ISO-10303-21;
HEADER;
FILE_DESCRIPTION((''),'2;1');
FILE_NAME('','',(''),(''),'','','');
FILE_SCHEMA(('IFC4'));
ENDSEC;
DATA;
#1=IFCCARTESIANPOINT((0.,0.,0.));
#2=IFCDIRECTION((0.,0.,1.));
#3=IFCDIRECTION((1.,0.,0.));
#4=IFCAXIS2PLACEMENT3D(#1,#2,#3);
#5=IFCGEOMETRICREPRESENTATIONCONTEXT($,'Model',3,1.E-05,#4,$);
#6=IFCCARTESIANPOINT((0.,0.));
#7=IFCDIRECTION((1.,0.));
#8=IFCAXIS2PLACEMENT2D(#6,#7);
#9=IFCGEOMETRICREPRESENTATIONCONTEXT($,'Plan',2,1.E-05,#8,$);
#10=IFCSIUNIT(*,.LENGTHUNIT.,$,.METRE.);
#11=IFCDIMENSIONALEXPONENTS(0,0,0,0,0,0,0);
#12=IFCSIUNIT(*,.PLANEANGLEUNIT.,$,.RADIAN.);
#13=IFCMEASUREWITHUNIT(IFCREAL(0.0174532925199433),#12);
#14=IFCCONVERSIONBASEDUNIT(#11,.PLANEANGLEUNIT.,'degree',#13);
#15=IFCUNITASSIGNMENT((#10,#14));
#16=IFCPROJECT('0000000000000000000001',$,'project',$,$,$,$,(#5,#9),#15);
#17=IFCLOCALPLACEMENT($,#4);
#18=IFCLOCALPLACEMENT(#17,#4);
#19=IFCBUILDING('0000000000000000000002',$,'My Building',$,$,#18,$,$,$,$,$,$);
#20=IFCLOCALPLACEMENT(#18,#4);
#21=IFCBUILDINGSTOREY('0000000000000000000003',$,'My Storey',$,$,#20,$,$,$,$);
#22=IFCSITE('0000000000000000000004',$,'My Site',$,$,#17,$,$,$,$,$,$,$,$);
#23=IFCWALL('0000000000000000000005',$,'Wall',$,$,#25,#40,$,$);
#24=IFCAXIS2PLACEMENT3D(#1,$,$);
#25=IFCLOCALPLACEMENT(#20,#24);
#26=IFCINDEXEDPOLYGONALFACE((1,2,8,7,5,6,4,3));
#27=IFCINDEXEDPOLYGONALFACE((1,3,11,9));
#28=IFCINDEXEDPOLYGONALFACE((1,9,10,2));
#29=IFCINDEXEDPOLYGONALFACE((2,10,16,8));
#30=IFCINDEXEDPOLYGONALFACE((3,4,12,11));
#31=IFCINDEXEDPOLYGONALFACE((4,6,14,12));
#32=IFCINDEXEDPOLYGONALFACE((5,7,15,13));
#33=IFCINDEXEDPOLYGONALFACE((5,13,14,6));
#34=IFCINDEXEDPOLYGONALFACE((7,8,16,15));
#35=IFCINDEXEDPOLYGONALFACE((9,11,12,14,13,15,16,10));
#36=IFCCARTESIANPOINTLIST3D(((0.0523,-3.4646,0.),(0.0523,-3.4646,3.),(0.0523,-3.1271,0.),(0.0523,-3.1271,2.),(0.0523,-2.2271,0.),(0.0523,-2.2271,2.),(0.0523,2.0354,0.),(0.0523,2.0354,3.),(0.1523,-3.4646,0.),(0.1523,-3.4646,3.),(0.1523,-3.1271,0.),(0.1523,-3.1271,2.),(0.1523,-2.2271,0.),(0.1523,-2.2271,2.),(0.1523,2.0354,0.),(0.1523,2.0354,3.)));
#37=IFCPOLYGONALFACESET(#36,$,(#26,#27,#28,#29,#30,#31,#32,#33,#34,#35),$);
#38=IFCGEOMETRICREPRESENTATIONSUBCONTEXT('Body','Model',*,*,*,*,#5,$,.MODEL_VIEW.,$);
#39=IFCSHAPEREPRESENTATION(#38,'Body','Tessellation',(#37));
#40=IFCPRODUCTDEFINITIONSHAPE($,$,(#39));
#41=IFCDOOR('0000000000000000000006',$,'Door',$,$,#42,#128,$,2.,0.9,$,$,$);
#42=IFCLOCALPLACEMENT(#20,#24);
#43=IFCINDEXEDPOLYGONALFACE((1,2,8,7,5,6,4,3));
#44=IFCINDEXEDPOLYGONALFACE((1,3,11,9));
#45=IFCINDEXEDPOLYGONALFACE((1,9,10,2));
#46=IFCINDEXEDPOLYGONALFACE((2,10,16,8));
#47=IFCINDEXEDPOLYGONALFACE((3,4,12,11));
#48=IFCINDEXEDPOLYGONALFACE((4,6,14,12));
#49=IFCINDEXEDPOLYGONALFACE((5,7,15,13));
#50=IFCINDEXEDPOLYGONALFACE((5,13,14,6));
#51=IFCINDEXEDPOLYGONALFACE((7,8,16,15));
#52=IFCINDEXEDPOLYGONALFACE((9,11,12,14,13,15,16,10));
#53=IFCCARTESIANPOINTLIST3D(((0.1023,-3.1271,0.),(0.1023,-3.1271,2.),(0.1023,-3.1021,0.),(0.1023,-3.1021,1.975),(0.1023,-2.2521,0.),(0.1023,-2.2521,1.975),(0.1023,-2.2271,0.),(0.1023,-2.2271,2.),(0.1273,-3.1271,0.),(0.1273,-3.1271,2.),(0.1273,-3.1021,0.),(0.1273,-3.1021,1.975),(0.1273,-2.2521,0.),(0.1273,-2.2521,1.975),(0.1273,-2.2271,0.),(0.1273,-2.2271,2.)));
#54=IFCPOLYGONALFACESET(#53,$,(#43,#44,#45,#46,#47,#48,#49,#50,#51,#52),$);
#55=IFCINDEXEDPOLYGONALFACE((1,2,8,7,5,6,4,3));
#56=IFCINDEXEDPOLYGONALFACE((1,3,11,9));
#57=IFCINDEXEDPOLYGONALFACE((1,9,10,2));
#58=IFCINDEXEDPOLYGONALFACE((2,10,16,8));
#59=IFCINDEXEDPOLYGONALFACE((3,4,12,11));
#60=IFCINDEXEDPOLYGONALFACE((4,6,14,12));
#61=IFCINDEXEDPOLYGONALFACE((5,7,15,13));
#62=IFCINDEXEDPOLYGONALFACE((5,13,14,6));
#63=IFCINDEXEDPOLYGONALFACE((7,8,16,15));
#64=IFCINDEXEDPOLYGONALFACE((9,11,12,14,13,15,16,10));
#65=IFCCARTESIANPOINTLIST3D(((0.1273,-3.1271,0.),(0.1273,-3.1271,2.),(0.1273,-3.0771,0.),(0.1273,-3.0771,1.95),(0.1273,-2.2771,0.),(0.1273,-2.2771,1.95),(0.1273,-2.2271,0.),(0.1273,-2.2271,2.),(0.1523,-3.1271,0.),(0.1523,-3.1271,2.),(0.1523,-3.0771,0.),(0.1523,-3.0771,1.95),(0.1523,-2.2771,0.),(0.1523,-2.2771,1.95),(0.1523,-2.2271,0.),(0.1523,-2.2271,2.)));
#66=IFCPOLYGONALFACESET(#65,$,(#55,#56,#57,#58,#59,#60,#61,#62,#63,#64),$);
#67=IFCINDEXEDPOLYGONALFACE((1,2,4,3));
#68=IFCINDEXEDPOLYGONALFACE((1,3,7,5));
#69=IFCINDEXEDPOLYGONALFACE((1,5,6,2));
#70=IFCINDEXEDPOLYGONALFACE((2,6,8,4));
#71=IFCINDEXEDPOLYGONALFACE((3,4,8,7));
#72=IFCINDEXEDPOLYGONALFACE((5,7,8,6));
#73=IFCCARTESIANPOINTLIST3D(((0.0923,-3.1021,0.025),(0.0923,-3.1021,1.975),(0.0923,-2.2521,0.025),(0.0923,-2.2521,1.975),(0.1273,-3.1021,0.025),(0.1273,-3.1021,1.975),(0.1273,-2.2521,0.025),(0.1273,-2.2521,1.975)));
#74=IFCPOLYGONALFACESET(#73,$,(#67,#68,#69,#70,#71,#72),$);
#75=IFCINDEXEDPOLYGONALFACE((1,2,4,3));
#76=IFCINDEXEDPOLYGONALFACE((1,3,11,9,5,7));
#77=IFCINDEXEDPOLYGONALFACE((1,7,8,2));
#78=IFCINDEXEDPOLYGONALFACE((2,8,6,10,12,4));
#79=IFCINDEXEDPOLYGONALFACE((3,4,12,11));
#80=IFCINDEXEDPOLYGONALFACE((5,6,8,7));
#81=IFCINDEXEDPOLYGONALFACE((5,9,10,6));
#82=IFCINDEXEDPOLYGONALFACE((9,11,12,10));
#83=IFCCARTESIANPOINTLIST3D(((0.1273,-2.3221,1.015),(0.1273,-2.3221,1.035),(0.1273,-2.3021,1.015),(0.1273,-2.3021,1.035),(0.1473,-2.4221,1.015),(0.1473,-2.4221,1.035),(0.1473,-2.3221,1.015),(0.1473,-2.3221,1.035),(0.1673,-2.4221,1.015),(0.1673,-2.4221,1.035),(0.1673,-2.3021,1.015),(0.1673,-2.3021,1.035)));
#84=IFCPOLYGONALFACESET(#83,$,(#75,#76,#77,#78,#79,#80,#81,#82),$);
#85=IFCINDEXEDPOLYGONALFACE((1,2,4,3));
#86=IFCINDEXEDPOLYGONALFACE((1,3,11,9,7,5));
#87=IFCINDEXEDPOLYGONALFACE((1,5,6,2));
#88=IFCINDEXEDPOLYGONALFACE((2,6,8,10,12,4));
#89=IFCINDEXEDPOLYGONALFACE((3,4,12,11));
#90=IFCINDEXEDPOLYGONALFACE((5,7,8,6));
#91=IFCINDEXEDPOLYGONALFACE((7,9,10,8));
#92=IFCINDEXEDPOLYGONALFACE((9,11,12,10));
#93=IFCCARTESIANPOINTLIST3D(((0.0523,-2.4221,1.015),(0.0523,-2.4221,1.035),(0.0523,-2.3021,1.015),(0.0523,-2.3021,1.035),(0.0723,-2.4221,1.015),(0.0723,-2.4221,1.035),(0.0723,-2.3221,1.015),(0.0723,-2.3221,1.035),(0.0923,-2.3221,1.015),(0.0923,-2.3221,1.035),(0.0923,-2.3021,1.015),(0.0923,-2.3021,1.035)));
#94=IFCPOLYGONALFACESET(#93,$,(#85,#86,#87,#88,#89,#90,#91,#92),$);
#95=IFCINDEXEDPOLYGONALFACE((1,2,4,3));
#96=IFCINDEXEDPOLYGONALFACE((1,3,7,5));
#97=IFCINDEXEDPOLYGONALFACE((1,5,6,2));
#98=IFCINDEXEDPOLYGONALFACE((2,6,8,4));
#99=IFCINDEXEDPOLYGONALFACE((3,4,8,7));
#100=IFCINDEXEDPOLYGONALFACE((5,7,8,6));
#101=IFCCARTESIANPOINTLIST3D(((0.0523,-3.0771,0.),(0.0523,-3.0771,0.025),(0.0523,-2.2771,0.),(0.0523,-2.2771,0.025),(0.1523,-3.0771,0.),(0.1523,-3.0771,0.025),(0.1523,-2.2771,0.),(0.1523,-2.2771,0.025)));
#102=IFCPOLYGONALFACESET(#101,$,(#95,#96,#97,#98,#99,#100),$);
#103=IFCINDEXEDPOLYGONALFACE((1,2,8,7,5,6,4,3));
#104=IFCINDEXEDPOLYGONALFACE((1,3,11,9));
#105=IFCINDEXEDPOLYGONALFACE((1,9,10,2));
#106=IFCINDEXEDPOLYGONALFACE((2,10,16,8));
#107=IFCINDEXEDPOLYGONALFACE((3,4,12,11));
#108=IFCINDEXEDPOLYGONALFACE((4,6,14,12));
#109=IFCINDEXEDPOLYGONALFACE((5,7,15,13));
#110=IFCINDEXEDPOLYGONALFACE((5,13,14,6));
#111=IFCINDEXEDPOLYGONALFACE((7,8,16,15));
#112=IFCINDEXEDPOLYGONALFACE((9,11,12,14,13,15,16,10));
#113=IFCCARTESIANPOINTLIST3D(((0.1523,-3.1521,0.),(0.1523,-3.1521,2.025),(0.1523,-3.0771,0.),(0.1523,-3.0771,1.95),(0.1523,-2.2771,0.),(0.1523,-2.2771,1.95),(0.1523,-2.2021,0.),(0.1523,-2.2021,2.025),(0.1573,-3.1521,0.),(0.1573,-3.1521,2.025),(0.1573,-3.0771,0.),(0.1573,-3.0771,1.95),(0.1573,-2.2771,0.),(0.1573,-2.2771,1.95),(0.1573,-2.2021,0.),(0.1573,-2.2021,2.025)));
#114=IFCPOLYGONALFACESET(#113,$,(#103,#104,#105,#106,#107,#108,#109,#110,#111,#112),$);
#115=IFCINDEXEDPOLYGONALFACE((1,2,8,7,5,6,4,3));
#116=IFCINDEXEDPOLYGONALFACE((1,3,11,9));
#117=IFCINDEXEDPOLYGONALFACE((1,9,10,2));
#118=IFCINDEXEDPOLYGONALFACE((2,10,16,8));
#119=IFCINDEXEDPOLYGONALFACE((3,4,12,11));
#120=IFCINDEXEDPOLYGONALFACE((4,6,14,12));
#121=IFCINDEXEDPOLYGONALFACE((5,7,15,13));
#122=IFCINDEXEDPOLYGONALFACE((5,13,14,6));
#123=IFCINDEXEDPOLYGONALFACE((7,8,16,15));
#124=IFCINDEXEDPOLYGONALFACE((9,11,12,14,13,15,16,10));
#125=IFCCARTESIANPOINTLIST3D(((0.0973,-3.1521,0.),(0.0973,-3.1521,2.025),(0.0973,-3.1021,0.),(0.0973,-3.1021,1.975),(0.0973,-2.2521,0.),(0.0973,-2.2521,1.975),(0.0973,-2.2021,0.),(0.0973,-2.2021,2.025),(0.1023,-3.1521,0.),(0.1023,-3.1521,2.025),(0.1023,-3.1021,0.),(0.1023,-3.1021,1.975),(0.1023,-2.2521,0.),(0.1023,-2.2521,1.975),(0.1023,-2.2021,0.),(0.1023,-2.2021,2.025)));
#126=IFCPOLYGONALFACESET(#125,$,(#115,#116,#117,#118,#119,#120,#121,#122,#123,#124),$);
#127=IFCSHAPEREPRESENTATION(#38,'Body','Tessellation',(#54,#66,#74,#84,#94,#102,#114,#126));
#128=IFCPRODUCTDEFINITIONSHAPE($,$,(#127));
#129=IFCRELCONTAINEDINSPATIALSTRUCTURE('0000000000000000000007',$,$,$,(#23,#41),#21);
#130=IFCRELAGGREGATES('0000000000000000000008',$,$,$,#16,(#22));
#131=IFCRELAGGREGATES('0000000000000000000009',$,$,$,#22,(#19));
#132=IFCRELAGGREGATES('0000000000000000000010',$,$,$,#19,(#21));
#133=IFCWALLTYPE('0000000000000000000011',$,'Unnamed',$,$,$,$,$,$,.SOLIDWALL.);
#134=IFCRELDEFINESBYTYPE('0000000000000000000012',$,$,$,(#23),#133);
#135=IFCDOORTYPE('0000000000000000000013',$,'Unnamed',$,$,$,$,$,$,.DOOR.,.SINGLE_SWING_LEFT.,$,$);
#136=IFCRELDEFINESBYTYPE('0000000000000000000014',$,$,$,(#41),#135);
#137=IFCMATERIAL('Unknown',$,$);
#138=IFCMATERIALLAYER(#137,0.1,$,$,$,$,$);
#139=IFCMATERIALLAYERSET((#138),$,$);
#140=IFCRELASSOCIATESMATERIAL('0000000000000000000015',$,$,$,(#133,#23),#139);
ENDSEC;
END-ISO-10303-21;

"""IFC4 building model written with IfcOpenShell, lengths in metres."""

from ifc_helpers import new_model, entity, si_unit, converted_unit, frame, origin_with_axes, origin_2d_with_axis, place, context, subcontext, project, spatial, line, indexed_curve, outline, extrude, shape, source, transform, mapped, material, layer, layer_set, layer_usage, type_object, type_shapes, element, fill, save


model = new_model("IFC4")

# Units and contexts
model_context = context("Model", 3, precision=1e-05, world=origin_with_axes())
plan_context = context("Plan", 2, precision=1e-05, world=origin_2d_with_axis())
body_context_1 = subcontext(model_context, "Body", "Model", "MODEL_VIEW")
body_context_2 = subcontext(plan_context, "Body", "Plan", "PLAN_VIEW")
ifc_project = project(units=[si_unit("LENGTHUNIT", "METRE"), converted_unit("PLANEANGLEUNIT", "degree", entity("IfcReal", 0.0174532925199433), si_unit("PLANEANGLEUNIT", "RADIAN"), dimensions=[0, 0, 0, 0, 0, 0, 0])], contexts=[model_context, plan_context])

# Site, building, storey
site_placement = place(None, origin_with_axes())
site = spatial("IfcSite", under=ifc_project, at=site_placement, Name="My Site")
building_placement = place(site_placement, origin_with_axes())
building = spatial("IfcBuilding", under=site, at=building_placement, Name="My Building")
storey_placement = place(building_placement, origin_with_axes())
storey = spatial("IfcBuildingStorey", under=building, at=storey_placement, Name="My Storey")

# Shared definitions
ifc_material = material(Name="Unknown")

# Shared definitions
ifc_layer_1 = layer(ifc_material, 0.1)
ifc_layer_set_1 = layer_set([ifc_layer_1])
wall_type = type_object("IfcWallType", Name="Unnamed", PredefinedType="SOLIDWALL", material=ifc_layer_set_1)

# Shared definitions
shared_shape_1 = source(origin_with_axes(), body_context_1, "Body", "SweptSolid", [
    extrude(outline(indexed_curve([(0.0, 0.0), (0.9, 0.0), (0.9, 2.0), (0.0, 2.0)], segments=[line(1, 2, 3, 4, 1)])), frame((0.0, -0.6, 0.0), z_axis=(0.0, -1.0, 0.0), x_axis=(1.0, 0.0, 0.0)), (0.0, 0.0, -1.0), 1.2),
])
door_type = type_object("IfcDoorType", Name="Unnamed", OperationType="SINGLE_SWING_LEFT", PredefinedType="DOOR")
shared_shape_2 = source(origin_with_axes(), body_context_1, "Body", "SweptSolid", [
    extrude(outline(indexed_curve([(0.0, 0.0), (0.0, 2.0), (0.9, 2.0), (0.9, 0.0), (0.875, 0.0), (0.875, 1.975), (0.025, 1.975), (0.025, 0.0)], segments=[line(1, 2, 3, 4, 5, 6, 7, 8, 1)])), frame((0.0, 0.025, 0.0), z_axis=(0.0, -1.0, 0.0), x_axis=(1.0, 0.0, 0.0)), (0.0, 0.0, -1.0), 0.025),
    extrude(outline(indexed_curve([(0.0, 0.0), (0.0, 2.0), (0.9, 2.0), (0.9, 0.0), (0.85, 0.0), (0.85, 1.95), (0.05, 1.95), (0.05, 0.0)], segments=[line(1, 2, 3, 4, 5, 6, 7, 8, 1)])), frame((0.0, 0.0, 0.0), z_axis=(0.0, -1.0, 0.0), x_axis=(1.0, 0.0, 0.0)), (0.0, 0.0, -1.0), 0.025),
    extrude(outline(indexed_curve([(0.0, 0.0), (0.85, 0.0), (0.85, 0.035), (0.0, 0.035)], segments=[line(1, 2, 3, 4, 1)])), frame((0.025, 0.025, 0.025), z_axis=(0.0, 0.0, 1.0), x_axis=(1.0, 0.0, 0.0)), (0.0, 0.0, 1.0), 1.95),
    extrude(outline(indexed_curve([(0.0, 0.0), (0.0, -0.04), (-0.12, -0.04), (-0.12, -0.02), (-0.02, -0.02), (-0.02, 0.0)], segments=[line(1, 2, 3, 4, 5, 6, 1)])), frame((0.825, 0.025, 1.015), z_axis=(0.0, 0.0, 1.0), x_axis=(1.0, 0.0, 0.0)), (0.0, 0.0, 1.0), 0.02),
    extrude(outline(indexed_curve([(0.0, 0.0), (0.0, 0.04), (-0.12, 0.04), (-0.12, 0.02), (-0.02, 0.02), (-0.02, 0.0)], segments=[line(1, 2, 3, 4, 5, 6, 1)])), frame((0.825, 0.06, 1.015), z_axis=(0.0, 0.0, 1.0), x_axis=(1.0, 0.0, 0.0)), (0.0, 0.0, 1.0), 0.02),
    extrude(outline(indexed_curve([(0.0, 0.0), (0.8, 0.0), (0.8, 0.1), (0.0, 0.1)], segments=[line(1, 2, 3, 4, 1)])), frame((0.05, 0.0, 0.0), z_axis=(0.0, 0.0, 1.0), x_axis=(1.0, 0.0, 0.0)), (0.0, 0.0, 1.0), 0.025),
    extrude(outline(indexed_curve([(0.0, 0.0), (0.0, 2.025), (0.95, 2.025), (0.95, 0.0), (0.875, 0.0), (0.875, 1.95), (0.075, 1.95), (0.075, 0.0)], segments=[line(1, 2, 3, 4, 5, 6, 7, 8, 1)])), frame((-0.025, -0.005, 0.0), z_axis=(0.0, -1.0, 0.0), x_axis=(1.0, 0.0, 0.0)), (0.0, 0.0, -1.0), 0.005),
    extrude(outline(indexed_curve([(0.0, 0.0), (0.0, 2.025), (0.95, 2.025), (0.95, 0.0), (0.9, 0.0), (0.9, 1.975), (0.05, 1.975), (0.05, 0.0)], segments=[line(1, 2, 3, 4, 5, 6, 7, 8, 1)])), frame((-0.025, 0.05, 0.0), z_axis=(0.0, -1.0, 0.0), x_axis=(1.0, 0.0, 0.0)), (0.0, 0.0, -1.0), 0.005),
])
shared_shape_3 = source(origin_with_axes(), body_context_2, "Body", "Curve2D", [
    entity("IfcIndexedPolyCurve", entity("IfcCartesianPointList2D", [[0.0, 0.0], [0.0, 0.05], [0.025, 0.05], [0.025, 0.025], [0.05, 0.025], [0.05, 0.0]]), [entity("IfcLineIndex", [1, 2, 3, 4, 5, 6, 1])]),
    entity("IfcIndexedPolyCurve", entity("IfcCartesianPointList2D", [[0.9, 0.0], [0.9, 0.05], [0.875, 0.05], [0.875, 0.025], [0.85, 0.025], [0.85, 0.0]]), [entity("IfcLineIndex", [1, 2, 3, 4, 5, 6, 1])]),
    entity("IfcTrimmedCurve", entity("IfcEllipse", entity("IfcAxis2Placement2D", entity("IfcCartesianPoint", [0.06, 0.05]), entity("IfcDirection", [1.0, 0.0])), 0.815, 0.85), [entity("IfcCartesianPoint", [0.875, 0.05])], [entity("IfcCartesianPoint", [0.06, 0.9])], True, "CARTESIAN"),
    entity("IfcIndexedPolyCurve", entity("IfcCartesianPointList2D", [[0.025, 0.05], [0.06, 0.05], [0.06, 0.9], [0.025, 0.9]]), [entity("IfcLineIndex", [1, 2, 3, 4, 1])]),
])
type_shapes(door_type, [shared_shape_2, shared_shape_3])

# Wall, opening, door
ifc_layer_usage_1 = layer_usage(ifc_layer_set_1, "AXIS2", "POSITIVE", 0.0)
wall_1_placement = place(storey_placement, frame((0.1523, -3.4646, 0.0), z_axis=(0.0, 0.0, 1.0), x_axis=(0.0, 1.0, 0.0)))
wall_1 = element("IfcWall", 1, at=wall_1_placement, inside=storey, type_object=wall_type, material=ifc_layer_usage_1, Name="Wall", context=body_context_1, shape_type="SweptSolid", body=[
    extrude(outline(indexed_curve([(0.0, 0.0), (0.0, 0.1), (5.5, 0.1), (5.5, 0.0)], segments=[line(1, 2, 3, 4, 1)])), origin_with_axes(), (0.0, 0.0, 1.0), 3.0),
])
opening_1_placement = place(wall_1_placement, frame((0.3375, 0.0, 0.0), z_axis=(0.0, 0.0, 1.0), x_axis=(1.0, 0.0, 0.0)))
opening_1 = element("IfcOpeningElement", 2, at=opening_1_placement, cuts=wall_1, PredefinedType="OPENING", context=body_context_1, shape_type="MappedRepresentation", body=[
    mapped(shared_shape_1, transform((0.0, 0.0, 0.0), x_axis=(1.0, 0.0, 0.0), y_axis=(0.0, 1.0, 0.0), z_axis=(0.0, 0.0, 1.0), scale=1.0)),
])
door_1_placement = place(opening_1_placement, origin_with_axes())
door_1 = element("IfcDoor", 3, at=door_1_placement, inside=storey, type_object=door_type, Name="Door", OverallHeight=2.0, OverallWidth=0.9, shapes=[
    shape(body_context_1, "Body", "MappedRepresentation", [mapped(shared_shape_2, transform((0.0, 0.0, 0.0), x_axis=(1.0, 0.0, 0.0), y_axis=(0.0, 1.0, 0.0), z_axis=(0.0, 0.0, 1.0), scale=1.0))]),
    shape(body_context_2, "Body", "MappedRepresentation", [mapped(shared_shape_3, transform((0.0, 0.0, 0.0), x_axis=(1.0, 0.0, 0.0), y_axis=(0.0, 1.0, 0.0), z_axis=(0.0, 0.0, 1.0), scale=1.0))]),
])
fill(opening_1, door_1)

save(model, "model.ifc")
